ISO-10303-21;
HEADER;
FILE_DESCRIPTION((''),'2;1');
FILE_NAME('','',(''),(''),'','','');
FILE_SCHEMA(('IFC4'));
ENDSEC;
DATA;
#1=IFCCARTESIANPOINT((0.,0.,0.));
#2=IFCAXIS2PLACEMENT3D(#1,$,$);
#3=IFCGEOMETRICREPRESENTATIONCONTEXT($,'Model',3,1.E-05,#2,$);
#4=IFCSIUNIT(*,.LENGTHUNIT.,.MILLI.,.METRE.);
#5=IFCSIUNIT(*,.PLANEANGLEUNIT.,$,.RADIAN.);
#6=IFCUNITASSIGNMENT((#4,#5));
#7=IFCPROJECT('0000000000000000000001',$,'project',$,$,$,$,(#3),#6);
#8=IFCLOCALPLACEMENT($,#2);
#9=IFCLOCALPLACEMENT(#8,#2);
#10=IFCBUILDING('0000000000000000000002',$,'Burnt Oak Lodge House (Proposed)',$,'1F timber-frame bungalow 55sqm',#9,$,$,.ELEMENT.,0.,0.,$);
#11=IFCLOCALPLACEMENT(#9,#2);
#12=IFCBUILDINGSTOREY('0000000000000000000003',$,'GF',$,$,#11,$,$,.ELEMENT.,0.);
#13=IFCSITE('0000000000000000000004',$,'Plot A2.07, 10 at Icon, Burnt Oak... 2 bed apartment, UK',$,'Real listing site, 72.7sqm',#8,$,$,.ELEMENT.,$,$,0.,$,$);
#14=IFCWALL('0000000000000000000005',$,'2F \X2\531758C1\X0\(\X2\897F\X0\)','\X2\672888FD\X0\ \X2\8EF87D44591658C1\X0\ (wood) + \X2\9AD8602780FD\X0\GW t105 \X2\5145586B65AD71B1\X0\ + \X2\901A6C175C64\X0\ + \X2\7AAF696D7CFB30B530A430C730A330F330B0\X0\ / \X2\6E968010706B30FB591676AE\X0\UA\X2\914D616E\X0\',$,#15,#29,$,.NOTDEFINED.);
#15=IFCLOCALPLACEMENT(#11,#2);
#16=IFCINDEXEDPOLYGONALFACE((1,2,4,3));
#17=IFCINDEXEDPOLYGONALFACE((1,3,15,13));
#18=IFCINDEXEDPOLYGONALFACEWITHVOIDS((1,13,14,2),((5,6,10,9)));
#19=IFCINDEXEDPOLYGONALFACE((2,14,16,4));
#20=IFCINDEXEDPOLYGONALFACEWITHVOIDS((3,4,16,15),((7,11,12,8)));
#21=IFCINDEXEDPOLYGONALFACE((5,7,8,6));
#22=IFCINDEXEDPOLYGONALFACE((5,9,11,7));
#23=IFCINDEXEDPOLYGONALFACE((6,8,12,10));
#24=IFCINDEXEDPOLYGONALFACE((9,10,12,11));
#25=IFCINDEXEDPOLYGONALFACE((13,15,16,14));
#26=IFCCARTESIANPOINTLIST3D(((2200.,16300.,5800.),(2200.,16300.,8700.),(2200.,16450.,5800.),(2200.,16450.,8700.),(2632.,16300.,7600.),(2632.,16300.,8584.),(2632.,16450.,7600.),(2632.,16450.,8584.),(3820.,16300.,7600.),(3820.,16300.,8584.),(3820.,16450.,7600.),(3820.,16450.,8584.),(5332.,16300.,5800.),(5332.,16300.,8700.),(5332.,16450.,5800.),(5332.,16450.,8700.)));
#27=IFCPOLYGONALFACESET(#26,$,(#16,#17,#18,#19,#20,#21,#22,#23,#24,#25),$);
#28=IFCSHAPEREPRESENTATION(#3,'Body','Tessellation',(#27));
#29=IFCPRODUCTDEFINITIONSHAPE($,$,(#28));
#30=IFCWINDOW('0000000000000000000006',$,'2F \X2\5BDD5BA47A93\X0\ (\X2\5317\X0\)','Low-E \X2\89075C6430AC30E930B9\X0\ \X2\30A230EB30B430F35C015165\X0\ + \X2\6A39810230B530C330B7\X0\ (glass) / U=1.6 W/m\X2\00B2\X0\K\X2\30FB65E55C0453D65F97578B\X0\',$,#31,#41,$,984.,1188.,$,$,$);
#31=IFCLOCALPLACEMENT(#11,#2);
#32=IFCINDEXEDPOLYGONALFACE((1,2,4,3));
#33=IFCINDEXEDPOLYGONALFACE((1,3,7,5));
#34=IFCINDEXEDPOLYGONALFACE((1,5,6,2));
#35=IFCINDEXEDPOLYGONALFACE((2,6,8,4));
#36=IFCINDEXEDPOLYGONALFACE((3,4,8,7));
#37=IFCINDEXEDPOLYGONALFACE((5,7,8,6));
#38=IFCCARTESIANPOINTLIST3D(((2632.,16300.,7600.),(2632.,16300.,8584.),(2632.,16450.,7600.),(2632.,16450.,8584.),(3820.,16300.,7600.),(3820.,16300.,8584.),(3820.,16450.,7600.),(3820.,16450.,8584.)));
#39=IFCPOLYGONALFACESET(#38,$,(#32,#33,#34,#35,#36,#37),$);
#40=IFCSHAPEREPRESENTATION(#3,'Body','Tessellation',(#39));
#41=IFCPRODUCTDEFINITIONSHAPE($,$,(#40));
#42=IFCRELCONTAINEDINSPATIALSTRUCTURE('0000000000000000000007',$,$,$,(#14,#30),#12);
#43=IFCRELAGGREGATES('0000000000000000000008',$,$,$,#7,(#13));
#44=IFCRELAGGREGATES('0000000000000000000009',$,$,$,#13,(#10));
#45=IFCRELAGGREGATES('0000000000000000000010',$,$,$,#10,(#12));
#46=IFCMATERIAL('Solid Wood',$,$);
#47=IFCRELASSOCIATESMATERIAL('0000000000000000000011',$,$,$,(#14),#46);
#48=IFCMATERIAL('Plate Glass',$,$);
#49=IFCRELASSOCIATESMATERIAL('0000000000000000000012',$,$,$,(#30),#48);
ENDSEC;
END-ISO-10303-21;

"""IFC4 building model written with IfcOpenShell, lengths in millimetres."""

from ifc_helpers import new_model, si_unit, frame, frame_2d, origin, place, context, project, spatial, rectangle, extrude, material, element, fill, save


model = new_model("IFC4")

# Units and contexts
model_context = context("Model", 3, precision=1e-05, world=origin())
ifc_project = project(units=[si_unit("LENGTHUNIT", "METRE", prefix="MILLI"), si_unit("PLANEANGLEUNIT", "RADIAN")], contexts=[model_context])

# Site, building, storey
site_placement = place(None, origin())
site = spatial("IfcSite", under=ifc_project, at=site_placement, Name="Plot A2.07, 10 at Icon, Burnt Oak... 2 bed apartment, UK", ObjectType="Real listing site, 72.7sqm", CompositionType="ELEMENT", RefElevation=0.0)
building_placement = place(site_placement, origin())
building = spatial("IfcBuilding", under=site, at=building_placement, Name="Burnt Oak Lodge House (Proposed)", ObjectType="1F timber-frame bungalow 55sqm", CompositionType="ELEMENT", ElevationOfRefHeight=0.0, ElevationOfTerrain=0.0)
storey_placement = place(building_placement, origin())
storey = spatial("IfcBuildingStorey", under=building, at=storey_placement, Name="GF", CompositionType="ELEMENT", Elevation=0.0)

# Shared definitions
ifc_material_1 = material(Name="Solid Wood")

# Wall, opening, window
wall_1_placement = place(storey_placement, frame((1100.0, 8150.0, 2900.0)))
wall_1 = element("IfcWall", 1, at=wall_1_placement, inside=storey, material=ifc_material_1, Name="2F 北壁(西)", Description="木製 軸組外壁 (wood) + 高性能GW t105 充填断熱 + 通気層 + 窯業系サイディング / 準耐火・外皮UA配慮", PredefinedType="NOTDEFINED", context=model_context, shape_type="SweptSolid", body=[
    extrude(rectangle(XDim=3132.0, YDim=150.0, at=frame_2d((1566.0, 75.0))), frame((1100.0, 8150.0, 2900.0)), (0.0, 0.0, 1.0), 2900.0),
])
opening_1_placement = place(storey_placement, frame((1316.0, 8150.0, 3800.0)))
opening_1 = element("IfcOpeningElement", 2, at=opening_1_placement, cuts=wall_1, PredefinedType="NOTDEFINED", context=model_context, shape_type="SweptSolid", body=[
    extrude(rectangle(XDim=1188.0, YDim=150.0, at=frame_2d((594.0, 75.0))), frame((1316.0, 8150.0, 3800.0)), (0.0, 0.0, 1.0), 984.0),
])
ifc_material_2 = material(Name="Plate Glass")
window_1_placement = place(storey_placement, frame((1316.0, 8150.0, 3800.0)))
window_1 = element("IfcWindow", 3, at=window_1_placement, inside=storey, material=ifc_material_2, Name="2F 寝室窓 (北)", Description="Low-E 複層ガラス アルゴン封入 + 樹脂サッシ (glass) / U=1.6 W/m²K・日射取得型", OverallHeight=984.0, OverallWidth=1188.0, context=model_context, shape_type="SweptSolid", body=[
    extrude(rectangle(XDim=1188.0, YDim=150.0, at=frame_2d((594.0, 75.0))), frame((1316.0, 8150.0, 3800.0)), (0.0, 0.0, 1.0), 984.0),
])
fill(opening_1, window_1)

save(model, "model.ifc")
